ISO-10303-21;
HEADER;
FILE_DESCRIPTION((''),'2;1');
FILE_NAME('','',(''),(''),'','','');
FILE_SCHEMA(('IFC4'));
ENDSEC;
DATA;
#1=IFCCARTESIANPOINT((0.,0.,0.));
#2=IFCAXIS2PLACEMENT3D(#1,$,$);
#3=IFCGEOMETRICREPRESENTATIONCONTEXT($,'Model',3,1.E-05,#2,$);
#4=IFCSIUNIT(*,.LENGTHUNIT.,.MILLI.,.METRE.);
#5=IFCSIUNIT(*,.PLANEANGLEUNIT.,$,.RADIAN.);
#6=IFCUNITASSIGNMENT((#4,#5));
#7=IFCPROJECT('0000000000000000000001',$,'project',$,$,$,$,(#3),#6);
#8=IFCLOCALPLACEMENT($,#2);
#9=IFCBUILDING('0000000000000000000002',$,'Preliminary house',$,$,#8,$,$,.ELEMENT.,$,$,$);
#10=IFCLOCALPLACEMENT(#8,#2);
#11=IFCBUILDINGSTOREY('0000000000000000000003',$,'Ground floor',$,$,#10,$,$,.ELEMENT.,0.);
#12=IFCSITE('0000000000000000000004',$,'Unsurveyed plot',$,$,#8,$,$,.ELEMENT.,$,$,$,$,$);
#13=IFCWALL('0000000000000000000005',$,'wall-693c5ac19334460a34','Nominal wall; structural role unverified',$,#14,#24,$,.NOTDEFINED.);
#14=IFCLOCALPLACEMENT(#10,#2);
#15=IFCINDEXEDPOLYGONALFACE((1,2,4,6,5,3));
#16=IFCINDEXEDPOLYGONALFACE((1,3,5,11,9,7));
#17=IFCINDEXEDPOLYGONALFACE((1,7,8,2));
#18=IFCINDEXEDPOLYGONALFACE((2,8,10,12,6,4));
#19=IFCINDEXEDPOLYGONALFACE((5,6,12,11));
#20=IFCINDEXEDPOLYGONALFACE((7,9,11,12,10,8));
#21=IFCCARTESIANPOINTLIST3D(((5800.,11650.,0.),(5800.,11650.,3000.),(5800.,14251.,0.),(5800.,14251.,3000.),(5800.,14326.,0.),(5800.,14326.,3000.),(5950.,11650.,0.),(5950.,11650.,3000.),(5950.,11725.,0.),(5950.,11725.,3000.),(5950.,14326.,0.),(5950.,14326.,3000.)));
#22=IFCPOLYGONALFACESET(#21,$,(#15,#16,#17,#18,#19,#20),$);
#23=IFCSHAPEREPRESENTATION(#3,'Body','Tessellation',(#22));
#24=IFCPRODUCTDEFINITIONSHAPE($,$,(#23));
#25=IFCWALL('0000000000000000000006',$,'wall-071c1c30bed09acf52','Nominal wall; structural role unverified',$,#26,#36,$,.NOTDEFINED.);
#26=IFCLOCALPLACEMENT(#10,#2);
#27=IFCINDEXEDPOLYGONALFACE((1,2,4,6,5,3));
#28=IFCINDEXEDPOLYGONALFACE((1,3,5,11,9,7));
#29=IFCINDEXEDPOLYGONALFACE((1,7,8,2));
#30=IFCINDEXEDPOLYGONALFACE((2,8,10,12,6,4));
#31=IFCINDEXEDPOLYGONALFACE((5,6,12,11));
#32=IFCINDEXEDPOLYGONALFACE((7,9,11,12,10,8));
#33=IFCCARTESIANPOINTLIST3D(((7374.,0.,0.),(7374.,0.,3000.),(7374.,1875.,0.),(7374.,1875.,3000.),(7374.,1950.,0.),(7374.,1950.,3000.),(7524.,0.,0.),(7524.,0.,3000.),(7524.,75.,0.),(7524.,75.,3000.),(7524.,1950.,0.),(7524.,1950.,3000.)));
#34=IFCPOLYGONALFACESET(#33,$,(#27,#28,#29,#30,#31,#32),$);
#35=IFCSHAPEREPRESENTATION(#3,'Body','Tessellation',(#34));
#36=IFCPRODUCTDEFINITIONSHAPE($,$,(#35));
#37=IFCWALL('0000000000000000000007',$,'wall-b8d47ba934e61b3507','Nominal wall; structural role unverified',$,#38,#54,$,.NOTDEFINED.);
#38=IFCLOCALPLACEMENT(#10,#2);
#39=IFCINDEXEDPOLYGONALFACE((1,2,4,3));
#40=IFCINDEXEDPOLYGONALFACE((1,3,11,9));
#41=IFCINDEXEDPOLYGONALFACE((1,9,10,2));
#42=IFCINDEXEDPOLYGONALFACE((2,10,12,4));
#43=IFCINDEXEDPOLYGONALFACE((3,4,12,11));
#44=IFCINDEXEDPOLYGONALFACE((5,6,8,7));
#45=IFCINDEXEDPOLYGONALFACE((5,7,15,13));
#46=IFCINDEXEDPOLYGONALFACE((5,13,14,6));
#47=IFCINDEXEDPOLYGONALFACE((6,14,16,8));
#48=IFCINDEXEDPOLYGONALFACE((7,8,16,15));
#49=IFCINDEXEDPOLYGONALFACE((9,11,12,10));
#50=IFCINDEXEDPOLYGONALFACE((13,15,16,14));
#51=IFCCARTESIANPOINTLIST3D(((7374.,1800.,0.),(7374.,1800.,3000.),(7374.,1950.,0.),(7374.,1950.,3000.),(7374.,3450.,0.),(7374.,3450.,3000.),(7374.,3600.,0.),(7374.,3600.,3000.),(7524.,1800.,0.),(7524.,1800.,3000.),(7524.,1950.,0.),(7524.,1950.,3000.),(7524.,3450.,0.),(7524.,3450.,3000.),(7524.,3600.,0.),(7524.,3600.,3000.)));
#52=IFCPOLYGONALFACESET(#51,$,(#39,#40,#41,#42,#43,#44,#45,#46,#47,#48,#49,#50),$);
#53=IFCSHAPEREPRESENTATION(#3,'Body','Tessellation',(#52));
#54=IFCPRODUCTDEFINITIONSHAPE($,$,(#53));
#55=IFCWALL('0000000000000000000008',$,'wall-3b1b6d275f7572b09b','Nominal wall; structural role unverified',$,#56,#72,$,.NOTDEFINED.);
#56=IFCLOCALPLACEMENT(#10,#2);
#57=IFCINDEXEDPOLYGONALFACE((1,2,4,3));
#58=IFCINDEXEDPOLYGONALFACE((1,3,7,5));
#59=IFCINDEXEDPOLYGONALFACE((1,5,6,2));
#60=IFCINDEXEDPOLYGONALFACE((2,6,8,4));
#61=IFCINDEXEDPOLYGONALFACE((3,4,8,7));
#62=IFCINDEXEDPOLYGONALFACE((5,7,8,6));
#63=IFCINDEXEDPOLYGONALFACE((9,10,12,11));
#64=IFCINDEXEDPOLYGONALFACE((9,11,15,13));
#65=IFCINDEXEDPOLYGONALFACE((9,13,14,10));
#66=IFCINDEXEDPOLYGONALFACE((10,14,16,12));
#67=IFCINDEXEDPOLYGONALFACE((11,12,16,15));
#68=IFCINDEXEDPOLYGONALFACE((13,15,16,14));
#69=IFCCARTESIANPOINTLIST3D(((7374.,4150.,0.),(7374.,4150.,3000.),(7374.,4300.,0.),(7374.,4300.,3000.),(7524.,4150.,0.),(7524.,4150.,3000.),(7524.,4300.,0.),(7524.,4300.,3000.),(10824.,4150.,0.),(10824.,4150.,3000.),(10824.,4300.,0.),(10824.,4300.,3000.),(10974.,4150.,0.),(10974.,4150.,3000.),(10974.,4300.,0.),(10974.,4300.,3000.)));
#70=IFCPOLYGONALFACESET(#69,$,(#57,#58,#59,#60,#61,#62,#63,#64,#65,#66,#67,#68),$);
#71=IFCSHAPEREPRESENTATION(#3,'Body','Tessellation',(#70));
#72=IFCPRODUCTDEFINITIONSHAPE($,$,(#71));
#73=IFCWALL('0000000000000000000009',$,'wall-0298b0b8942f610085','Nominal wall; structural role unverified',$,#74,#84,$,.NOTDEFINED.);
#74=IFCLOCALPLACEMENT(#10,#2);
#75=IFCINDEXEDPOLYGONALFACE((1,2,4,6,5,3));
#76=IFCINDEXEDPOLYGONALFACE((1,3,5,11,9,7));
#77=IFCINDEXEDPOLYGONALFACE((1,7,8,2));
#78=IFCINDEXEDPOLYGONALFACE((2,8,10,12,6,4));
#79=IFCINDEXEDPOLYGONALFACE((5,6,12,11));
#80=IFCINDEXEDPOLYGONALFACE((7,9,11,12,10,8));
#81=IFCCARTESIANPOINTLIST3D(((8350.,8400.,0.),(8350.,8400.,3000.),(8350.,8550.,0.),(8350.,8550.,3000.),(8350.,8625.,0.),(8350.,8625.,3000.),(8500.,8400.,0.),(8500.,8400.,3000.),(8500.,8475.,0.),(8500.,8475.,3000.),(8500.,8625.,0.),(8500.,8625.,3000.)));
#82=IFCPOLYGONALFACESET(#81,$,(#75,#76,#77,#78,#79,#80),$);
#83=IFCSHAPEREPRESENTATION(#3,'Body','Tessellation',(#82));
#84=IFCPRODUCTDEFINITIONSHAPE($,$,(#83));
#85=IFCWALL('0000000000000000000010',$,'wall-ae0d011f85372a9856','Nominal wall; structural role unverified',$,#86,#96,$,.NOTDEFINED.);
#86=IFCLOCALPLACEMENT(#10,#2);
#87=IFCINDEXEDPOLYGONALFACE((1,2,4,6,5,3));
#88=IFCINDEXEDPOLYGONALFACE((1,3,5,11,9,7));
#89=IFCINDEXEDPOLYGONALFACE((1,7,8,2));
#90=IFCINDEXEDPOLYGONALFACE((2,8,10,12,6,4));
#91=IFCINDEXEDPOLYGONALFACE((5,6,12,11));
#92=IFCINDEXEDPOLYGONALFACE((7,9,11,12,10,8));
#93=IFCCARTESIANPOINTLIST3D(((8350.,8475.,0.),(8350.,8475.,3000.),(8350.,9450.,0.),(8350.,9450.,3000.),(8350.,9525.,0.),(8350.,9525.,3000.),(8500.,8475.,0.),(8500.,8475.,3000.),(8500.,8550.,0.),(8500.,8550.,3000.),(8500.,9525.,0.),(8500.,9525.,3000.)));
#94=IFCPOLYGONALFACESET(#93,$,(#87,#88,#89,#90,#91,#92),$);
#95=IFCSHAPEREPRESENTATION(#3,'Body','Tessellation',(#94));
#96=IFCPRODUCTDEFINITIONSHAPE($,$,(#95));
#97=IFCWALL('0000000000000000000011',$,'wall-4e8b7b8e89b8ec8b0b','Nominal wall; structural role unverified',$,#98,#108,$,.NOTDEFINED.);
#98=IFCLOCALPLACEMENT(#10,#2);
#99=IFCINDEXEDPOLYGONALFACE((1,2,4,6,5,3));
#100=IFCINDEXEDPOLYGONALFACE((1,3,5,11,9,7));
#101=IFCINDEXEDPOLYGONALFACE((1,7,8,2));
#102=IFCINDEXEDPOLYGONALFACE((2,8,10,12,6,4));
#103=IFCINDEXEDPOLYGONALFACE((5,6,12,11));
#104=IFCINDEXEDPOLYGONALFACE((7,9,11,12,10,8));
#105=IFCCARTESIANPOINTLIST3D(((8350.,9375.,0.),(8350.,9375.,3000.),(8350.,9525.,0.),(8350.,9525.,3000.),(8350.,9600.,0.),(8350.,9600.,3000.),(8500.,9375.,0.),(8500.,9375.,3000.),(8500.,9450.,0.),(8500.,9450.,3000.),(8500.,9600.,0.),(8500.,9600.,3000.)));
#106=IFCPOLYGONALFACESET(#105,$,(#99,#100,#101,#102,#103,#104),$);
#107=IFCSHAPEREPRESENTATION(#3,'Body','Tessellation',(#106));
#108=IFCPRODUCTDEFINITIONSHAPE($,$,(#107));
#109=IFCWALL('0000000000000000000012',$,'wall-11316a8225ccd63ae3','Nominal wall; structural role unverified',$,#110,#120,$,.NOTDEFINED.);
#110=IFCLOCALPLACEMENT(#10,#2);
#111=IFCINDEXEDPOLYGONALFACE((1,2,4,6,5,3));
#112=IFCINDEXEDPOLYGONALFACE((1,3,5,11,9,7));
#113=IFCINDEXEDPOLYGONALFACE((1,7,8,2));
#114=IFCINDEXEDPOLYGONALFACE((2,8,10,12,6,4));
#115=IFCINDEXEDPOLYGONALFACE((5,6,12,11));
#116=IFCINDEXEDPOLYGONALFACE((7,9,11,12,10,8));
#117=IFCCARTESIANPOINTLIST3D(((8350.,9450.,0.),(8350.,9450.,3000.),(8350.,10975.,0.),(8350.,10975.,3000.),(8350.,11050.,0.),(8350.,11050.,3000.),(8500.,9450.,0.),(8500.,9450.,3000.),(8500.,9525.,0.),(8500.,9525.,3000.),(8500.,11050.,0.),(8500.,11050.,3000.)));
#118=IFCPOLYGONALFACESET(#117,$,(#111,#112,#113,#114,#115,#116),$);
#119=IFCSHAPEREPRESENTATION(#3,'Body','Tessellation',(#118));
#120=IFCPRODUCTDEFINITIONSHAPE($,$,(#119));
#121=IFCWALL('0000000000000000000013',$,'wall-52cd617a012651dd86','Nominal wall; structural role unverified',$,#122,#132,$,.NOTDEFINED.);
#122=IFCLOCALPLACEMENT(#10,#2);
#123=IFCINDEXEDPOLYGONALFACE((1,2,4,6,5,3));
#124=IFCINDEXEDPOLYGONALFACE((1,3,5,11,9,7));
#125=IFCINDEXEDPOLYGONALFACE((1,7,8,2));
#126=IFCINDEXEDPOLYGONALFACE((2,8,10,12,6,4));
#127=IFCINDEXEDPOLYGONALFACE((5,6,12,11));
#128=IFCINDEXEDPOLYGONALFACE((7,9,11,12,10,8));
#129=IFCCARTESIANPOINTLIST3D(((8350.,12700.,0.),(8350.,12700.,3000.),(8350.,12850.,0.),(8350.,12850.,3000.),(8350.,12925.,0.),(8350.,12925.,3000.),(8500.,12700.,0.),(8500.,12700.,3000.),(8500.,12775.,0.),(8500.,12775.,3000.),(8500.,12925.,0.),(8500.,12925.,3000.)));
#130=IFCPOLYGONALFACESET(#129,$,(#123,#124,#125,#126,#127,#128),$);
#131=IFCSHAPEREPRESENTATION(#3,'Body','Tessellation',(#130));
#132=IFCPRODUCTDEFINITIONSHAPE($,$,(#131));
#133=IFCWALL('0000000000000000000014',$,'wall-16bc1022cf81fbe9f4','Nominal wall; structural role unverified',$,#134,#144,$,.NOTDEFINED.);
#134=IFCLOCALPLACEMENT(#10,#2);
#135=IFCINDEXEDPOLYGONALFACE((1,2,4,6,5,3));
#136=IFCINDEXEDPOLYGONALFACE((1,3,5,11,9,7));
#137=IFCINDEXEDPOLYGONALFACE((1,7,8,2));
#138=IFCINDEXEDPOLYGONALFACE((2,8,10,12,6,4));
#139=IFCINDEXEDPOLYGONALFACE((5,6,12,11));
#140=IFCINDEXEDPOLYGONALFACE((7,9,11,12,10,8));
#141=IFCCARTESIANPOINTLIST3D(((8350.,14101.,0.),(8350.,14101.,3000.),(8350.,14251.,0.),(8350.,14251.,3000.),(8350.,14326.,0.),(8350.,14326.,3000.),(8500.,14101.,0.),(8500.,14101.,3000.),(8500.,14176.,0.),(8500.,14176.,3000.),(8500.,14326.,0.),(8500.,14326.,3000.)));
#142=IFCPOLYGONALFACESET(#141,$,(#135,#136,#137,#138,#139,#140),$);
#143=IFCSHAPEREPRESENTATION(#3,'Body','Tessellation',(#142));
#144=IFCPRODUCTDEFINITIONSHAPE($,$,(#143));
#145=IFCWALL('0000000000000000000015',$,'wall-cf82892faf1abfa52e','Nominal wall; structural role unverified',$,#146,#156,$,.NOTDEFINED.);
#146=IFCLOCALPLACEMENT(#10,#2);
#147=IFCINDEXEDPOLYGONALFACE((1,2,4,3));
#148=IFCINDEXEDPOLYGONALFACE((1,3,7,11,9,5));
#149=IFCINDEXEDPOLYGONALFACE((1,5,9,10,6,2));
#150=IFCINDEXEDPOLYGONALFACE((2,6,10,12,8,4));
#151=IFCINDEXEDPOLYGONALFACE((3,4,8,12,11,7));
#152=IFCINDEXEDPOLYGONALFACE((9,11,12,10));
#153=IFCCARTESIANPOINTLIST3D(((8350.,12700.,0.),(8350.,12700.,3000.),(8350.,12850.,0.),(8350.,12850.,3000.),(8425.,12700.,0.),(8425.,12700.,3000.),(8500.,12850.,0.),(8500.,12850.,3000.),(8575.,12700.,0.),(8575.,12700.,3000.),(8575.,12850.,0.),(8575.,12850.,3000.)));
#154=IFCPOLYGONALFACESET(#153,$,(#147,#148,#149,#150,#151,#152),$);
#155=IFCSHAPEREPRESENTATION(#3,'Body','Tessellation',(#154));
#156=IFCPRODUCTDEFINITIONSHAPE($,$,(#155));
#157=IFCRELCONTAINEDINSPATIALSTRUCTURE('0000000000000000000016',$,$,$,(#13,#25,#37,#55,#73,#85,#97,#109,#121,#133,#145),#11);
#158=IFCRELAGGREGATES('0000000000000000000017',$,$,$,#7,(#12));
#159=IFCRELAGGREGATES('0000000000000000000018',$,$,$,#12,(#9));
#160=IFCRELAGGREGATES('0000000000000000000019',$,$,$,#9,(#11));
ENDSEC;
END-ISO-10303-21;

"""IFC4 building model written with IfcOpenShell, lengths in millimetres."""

from ifc_helpers import new_model, si_unit, origin, place, context, project, spatial, polyline, outline, extrude, element, save


model = new_model("IFC4")

# Units and contexts
model_context = context("Model", 3, precision=1e-05, world=origin())
ifc_project = project(units=[si_unit("LENGTHUNIT", "METRE", prefix="MILLI"), si_unit("PLANEANGLEUNIT", "RADIAN")], contexts=[model_context])

# Site, building, storey
placement_1 = place(None, origin())
site = spatial("IfcSite", under=ifc_project, at=placement_1, Name="Unsurveyed plot", CompositionType="ELEMENT")
building = spatial("IfcBuilding", under=site, at=placement_1, Name="Preliminary house", CompositionType="ELEMENT")
placement_2 = place(placement_1, origin())
storey = spatial("IfcBuildingStorey", under=building, at=placement_2, Name="Ground floor", CompositionType="ELEMENT", Elevation=0.0)

# Wall
element("IfcWall", 1, at=placement_2, inside=storey, Name="wall-693c5ac19334460a34", Description="Nominal wall; structural role unverified", PredefinedType="NOTDEFINED", context=model_context, shape_type="SweptSolid", body=[
    extrude(outline(polyline([(5800.0, 14251.0), (5800.0, 14326.0), (5950.0, 14326.0), (5950.0, 11725.0), (5950.0, 11650.0), (5800.0, 11650.0), (5800.0, 14251.0)])), origin(), (0.0, 0.0, 1.0), 3000.0),
])

# Wall
element("IfcWall", 2, at=placement_2, inside=storey, Name="wall-071c1c30bed09acf52", Description="Nominal wall; structural role unverified", PredefinedType="NOTDEFINED", context=model_context, shape_type="SweptSolid", body=[
    extrude(outline(polyline([(7374.0, 1875.0), (7374.0, 1950.0), (7524.0, 1950.0), (7524.0, 75.0), (7524.0, 0.0), (7374.0, 0.0), (7374.0, 1875.0)])), origin(), (0.0, 0.0, 1.0), 3000.0),
])

# Walls, openings
wall_1 = element("IfcWall", 3, at=placement_2, inside=storey, Name="wall-b8d47ba934e61b3507", Description="Nominal wall; structural role unverified", PredefinedType="NOTDEFINED", context=model_context, shape_type="SweptSolid", body=[
    extrude(outline(polyline([(7374.0, 3525.0), (7374.0, 3600.0), (7524.0, 3600.0), (7524.0, 1875.0), (7524.0, 1800.0), (7374.0, 1800.0), (7374.0, 3525.0)])), origin(), (0.0, 0.0, 1.0), 3000.0),
])
element("IfcOpeningElement", 4, at=placement_2, cuts=wall_1, PredefinedType="OPENING", context=model_context, shape_type="SweptSolid", body=[
    extrude(outline(polyline([(7899.0, 1950.0), (7899.0, 3450.0), (6999.0, 3450.0), (6999.0, 1950.0), (7899.0, 1950.0)])), origin(), (0.0, 0.0, 1.0), 3000.0),
])
wall_2 = element("IfcWall", 5, at=placement_2, inside=storey, Name="wall-3b1b6d275f7572b09b", Description="Nominal wall; structural role unverified", PredefinedType="NOTDEFINED", context=model_context, shape_type="SweptSolid", body=[
    extrude(outline(polyline([(10899.0, 4300.0), (10974.0, 4300.0), (10974.0, 4150.0), (7449.0, 4150.0), (7374.0, 4150.0), (7374.0, 4300.0), (10899.0, 4300.0)])), origin(), (0.0, 0.0, 1.0), 3000.0),
])
element("IfcOpeningElement", 6, at=placement_2, cuts=wall_2, PredefinedType="OPENING", context=model_context, shape_type="SweptSolid", body=[
    extrude(outline(polyline([(7524.0, 3775.0), (10824.0, 3775.0), (10824.0, 4675.0), (7524.0, 4675.0), (7524.0, 3775.0)])), origin(), (0.0, 0.0, 1.0), 3000.0),
])

# Walls
element("IfcWall", 7, at=placement_2, inside=storey, Name="wall-0298b0b8942f610085", Description="Nominal wall; structural role unverified", PredefinedType="NOTDEFINED", context=model_context, shape_type="SweptSolid", body=[
    extrude(outline(polyline([(8350.0, 8550.0), (8350.0, 8625.0), (8500.0, 8625.0), (8500.0, 8475.0), (8500.0, 8400.0), (8350.0, 8400.0), (8350.0, 8550.0)])), origin(), (0.0, 0.0, 1.0), 3000.0),
])
element("IfcWall", 8, at=placement_2, inside=storey, Name="wall-ae0d011f85372a9856", Description="Nominal wall; structural role unverified", PredefinedType="NOTDEFINED", context=model_context, shape_type="SweptSolid", body=[
    extrude(outline(polyline([(8350.0, 9450.0), (8350.0, 9525.0), (8500.0, 9525.0), (8500.0, 8550.0), (8500.0, 8475.0), (8350.0, 8475.0), (8350.0, 9450.0)])), origin(), (0.0, 0.0, 1.0), 3000.0),
])
element("IfcWall", 9, at=placement_2, inside=storey, Name="wall-4e8b7b8e89b8ec8b0b", Description="Nominal wall; structural role unverified", PredefinedType="NOTDEFINED", context=model_context, shape_type="SweptSolid", body=[
    extrude(outline(polyline([(8350.0, 9525.0), (8350.0, 9600.0), (8500.0, 9600.0), (8500.0, 9450.0), (8500.0, 9375.0), (8350.0, 9375.0), (8350.0, 9525.0)])), origin(), (0.0, 0.0, 1.0), 3000.0),
])

# Wall
element("IfcWall", 10, at=placement_2, inside=storey, Name="wall-11316a8225ccd63ae3", Description="Nominal wall; structural role unverified", PredefinedType="NOTDEFINED", context=model_context, shape_type="SweptSolid", body=[
    extrude(outline(polyline([(8350.0, 10975.0), (8350.0, 11050.0), (8500.0, 11050.0), (8500.0, 9525.0), (8500.0, 9450.0), (8350.0, 9450.0), (8350.0, 10975.0)])), origin(), (0.0, 0.0, 1.0), 3000.0),
])

# Wall
element("IfcWall", 11, at=placement_2, inside=storey, Name="wall-52cd617a012651dd86", Description="Nominal wall; structural role unverified", PredefinedType="NOTDEFINED", context=model_context, shape_type="SweptSolid", body=[
    extrude(outline(polyline([(8350.0, 12850.0), (8350.0, 12925.0), (8500.0, 12925.0), (8500.0, 12775.0), (8500.0, 12700.0), (8350.0, 12700.0), (8350.0, 12850.0)])), origin(), (0.0, 0.0, 1.0), 3000.0),
])

# Walls
element("IfcWall", 12, at=placement_2, inside=storey, Name="wall-16bc1022cf81fbe9f4", Description="Nominal wall; structural role unverified", PredefinedType="NOTDEFINED", context=model_context, shape_type="SweptSolid", body=[
    extrude(outline(polyline([(8350.0, 14251.0), (8350.0, 14326.0), (8500.0, 14326.0), (8500.0, 14176.0), (8500.0, 14101.0), (8350.0, 14101.0), (8350.0, 14251.0)])), origin(), (0.0, 0.0, 1.0), 3000.0),
])
element("IfcWall", 13, at=placement_2, inside=storey, Name="wall-cf82892faf1abfa52e", Description="Nominal wall; structural role unverified", PredefinedType="NOTDEFINED", context=model_context, shape_type="SweptSolid", body=[
    extrude(outline(polyline([(8500.0, 12850.0), (8575.0, 12850.0), (8575.0, 12700.0), (8425.0, 12700.0), (8350.0, 12700.0), (8350.0, 12850.0), (8500.0, 12850.0)])), origin(), (0.0, 0.0, 1.0), 3000.0),
])

save(model, "model.ifc")
